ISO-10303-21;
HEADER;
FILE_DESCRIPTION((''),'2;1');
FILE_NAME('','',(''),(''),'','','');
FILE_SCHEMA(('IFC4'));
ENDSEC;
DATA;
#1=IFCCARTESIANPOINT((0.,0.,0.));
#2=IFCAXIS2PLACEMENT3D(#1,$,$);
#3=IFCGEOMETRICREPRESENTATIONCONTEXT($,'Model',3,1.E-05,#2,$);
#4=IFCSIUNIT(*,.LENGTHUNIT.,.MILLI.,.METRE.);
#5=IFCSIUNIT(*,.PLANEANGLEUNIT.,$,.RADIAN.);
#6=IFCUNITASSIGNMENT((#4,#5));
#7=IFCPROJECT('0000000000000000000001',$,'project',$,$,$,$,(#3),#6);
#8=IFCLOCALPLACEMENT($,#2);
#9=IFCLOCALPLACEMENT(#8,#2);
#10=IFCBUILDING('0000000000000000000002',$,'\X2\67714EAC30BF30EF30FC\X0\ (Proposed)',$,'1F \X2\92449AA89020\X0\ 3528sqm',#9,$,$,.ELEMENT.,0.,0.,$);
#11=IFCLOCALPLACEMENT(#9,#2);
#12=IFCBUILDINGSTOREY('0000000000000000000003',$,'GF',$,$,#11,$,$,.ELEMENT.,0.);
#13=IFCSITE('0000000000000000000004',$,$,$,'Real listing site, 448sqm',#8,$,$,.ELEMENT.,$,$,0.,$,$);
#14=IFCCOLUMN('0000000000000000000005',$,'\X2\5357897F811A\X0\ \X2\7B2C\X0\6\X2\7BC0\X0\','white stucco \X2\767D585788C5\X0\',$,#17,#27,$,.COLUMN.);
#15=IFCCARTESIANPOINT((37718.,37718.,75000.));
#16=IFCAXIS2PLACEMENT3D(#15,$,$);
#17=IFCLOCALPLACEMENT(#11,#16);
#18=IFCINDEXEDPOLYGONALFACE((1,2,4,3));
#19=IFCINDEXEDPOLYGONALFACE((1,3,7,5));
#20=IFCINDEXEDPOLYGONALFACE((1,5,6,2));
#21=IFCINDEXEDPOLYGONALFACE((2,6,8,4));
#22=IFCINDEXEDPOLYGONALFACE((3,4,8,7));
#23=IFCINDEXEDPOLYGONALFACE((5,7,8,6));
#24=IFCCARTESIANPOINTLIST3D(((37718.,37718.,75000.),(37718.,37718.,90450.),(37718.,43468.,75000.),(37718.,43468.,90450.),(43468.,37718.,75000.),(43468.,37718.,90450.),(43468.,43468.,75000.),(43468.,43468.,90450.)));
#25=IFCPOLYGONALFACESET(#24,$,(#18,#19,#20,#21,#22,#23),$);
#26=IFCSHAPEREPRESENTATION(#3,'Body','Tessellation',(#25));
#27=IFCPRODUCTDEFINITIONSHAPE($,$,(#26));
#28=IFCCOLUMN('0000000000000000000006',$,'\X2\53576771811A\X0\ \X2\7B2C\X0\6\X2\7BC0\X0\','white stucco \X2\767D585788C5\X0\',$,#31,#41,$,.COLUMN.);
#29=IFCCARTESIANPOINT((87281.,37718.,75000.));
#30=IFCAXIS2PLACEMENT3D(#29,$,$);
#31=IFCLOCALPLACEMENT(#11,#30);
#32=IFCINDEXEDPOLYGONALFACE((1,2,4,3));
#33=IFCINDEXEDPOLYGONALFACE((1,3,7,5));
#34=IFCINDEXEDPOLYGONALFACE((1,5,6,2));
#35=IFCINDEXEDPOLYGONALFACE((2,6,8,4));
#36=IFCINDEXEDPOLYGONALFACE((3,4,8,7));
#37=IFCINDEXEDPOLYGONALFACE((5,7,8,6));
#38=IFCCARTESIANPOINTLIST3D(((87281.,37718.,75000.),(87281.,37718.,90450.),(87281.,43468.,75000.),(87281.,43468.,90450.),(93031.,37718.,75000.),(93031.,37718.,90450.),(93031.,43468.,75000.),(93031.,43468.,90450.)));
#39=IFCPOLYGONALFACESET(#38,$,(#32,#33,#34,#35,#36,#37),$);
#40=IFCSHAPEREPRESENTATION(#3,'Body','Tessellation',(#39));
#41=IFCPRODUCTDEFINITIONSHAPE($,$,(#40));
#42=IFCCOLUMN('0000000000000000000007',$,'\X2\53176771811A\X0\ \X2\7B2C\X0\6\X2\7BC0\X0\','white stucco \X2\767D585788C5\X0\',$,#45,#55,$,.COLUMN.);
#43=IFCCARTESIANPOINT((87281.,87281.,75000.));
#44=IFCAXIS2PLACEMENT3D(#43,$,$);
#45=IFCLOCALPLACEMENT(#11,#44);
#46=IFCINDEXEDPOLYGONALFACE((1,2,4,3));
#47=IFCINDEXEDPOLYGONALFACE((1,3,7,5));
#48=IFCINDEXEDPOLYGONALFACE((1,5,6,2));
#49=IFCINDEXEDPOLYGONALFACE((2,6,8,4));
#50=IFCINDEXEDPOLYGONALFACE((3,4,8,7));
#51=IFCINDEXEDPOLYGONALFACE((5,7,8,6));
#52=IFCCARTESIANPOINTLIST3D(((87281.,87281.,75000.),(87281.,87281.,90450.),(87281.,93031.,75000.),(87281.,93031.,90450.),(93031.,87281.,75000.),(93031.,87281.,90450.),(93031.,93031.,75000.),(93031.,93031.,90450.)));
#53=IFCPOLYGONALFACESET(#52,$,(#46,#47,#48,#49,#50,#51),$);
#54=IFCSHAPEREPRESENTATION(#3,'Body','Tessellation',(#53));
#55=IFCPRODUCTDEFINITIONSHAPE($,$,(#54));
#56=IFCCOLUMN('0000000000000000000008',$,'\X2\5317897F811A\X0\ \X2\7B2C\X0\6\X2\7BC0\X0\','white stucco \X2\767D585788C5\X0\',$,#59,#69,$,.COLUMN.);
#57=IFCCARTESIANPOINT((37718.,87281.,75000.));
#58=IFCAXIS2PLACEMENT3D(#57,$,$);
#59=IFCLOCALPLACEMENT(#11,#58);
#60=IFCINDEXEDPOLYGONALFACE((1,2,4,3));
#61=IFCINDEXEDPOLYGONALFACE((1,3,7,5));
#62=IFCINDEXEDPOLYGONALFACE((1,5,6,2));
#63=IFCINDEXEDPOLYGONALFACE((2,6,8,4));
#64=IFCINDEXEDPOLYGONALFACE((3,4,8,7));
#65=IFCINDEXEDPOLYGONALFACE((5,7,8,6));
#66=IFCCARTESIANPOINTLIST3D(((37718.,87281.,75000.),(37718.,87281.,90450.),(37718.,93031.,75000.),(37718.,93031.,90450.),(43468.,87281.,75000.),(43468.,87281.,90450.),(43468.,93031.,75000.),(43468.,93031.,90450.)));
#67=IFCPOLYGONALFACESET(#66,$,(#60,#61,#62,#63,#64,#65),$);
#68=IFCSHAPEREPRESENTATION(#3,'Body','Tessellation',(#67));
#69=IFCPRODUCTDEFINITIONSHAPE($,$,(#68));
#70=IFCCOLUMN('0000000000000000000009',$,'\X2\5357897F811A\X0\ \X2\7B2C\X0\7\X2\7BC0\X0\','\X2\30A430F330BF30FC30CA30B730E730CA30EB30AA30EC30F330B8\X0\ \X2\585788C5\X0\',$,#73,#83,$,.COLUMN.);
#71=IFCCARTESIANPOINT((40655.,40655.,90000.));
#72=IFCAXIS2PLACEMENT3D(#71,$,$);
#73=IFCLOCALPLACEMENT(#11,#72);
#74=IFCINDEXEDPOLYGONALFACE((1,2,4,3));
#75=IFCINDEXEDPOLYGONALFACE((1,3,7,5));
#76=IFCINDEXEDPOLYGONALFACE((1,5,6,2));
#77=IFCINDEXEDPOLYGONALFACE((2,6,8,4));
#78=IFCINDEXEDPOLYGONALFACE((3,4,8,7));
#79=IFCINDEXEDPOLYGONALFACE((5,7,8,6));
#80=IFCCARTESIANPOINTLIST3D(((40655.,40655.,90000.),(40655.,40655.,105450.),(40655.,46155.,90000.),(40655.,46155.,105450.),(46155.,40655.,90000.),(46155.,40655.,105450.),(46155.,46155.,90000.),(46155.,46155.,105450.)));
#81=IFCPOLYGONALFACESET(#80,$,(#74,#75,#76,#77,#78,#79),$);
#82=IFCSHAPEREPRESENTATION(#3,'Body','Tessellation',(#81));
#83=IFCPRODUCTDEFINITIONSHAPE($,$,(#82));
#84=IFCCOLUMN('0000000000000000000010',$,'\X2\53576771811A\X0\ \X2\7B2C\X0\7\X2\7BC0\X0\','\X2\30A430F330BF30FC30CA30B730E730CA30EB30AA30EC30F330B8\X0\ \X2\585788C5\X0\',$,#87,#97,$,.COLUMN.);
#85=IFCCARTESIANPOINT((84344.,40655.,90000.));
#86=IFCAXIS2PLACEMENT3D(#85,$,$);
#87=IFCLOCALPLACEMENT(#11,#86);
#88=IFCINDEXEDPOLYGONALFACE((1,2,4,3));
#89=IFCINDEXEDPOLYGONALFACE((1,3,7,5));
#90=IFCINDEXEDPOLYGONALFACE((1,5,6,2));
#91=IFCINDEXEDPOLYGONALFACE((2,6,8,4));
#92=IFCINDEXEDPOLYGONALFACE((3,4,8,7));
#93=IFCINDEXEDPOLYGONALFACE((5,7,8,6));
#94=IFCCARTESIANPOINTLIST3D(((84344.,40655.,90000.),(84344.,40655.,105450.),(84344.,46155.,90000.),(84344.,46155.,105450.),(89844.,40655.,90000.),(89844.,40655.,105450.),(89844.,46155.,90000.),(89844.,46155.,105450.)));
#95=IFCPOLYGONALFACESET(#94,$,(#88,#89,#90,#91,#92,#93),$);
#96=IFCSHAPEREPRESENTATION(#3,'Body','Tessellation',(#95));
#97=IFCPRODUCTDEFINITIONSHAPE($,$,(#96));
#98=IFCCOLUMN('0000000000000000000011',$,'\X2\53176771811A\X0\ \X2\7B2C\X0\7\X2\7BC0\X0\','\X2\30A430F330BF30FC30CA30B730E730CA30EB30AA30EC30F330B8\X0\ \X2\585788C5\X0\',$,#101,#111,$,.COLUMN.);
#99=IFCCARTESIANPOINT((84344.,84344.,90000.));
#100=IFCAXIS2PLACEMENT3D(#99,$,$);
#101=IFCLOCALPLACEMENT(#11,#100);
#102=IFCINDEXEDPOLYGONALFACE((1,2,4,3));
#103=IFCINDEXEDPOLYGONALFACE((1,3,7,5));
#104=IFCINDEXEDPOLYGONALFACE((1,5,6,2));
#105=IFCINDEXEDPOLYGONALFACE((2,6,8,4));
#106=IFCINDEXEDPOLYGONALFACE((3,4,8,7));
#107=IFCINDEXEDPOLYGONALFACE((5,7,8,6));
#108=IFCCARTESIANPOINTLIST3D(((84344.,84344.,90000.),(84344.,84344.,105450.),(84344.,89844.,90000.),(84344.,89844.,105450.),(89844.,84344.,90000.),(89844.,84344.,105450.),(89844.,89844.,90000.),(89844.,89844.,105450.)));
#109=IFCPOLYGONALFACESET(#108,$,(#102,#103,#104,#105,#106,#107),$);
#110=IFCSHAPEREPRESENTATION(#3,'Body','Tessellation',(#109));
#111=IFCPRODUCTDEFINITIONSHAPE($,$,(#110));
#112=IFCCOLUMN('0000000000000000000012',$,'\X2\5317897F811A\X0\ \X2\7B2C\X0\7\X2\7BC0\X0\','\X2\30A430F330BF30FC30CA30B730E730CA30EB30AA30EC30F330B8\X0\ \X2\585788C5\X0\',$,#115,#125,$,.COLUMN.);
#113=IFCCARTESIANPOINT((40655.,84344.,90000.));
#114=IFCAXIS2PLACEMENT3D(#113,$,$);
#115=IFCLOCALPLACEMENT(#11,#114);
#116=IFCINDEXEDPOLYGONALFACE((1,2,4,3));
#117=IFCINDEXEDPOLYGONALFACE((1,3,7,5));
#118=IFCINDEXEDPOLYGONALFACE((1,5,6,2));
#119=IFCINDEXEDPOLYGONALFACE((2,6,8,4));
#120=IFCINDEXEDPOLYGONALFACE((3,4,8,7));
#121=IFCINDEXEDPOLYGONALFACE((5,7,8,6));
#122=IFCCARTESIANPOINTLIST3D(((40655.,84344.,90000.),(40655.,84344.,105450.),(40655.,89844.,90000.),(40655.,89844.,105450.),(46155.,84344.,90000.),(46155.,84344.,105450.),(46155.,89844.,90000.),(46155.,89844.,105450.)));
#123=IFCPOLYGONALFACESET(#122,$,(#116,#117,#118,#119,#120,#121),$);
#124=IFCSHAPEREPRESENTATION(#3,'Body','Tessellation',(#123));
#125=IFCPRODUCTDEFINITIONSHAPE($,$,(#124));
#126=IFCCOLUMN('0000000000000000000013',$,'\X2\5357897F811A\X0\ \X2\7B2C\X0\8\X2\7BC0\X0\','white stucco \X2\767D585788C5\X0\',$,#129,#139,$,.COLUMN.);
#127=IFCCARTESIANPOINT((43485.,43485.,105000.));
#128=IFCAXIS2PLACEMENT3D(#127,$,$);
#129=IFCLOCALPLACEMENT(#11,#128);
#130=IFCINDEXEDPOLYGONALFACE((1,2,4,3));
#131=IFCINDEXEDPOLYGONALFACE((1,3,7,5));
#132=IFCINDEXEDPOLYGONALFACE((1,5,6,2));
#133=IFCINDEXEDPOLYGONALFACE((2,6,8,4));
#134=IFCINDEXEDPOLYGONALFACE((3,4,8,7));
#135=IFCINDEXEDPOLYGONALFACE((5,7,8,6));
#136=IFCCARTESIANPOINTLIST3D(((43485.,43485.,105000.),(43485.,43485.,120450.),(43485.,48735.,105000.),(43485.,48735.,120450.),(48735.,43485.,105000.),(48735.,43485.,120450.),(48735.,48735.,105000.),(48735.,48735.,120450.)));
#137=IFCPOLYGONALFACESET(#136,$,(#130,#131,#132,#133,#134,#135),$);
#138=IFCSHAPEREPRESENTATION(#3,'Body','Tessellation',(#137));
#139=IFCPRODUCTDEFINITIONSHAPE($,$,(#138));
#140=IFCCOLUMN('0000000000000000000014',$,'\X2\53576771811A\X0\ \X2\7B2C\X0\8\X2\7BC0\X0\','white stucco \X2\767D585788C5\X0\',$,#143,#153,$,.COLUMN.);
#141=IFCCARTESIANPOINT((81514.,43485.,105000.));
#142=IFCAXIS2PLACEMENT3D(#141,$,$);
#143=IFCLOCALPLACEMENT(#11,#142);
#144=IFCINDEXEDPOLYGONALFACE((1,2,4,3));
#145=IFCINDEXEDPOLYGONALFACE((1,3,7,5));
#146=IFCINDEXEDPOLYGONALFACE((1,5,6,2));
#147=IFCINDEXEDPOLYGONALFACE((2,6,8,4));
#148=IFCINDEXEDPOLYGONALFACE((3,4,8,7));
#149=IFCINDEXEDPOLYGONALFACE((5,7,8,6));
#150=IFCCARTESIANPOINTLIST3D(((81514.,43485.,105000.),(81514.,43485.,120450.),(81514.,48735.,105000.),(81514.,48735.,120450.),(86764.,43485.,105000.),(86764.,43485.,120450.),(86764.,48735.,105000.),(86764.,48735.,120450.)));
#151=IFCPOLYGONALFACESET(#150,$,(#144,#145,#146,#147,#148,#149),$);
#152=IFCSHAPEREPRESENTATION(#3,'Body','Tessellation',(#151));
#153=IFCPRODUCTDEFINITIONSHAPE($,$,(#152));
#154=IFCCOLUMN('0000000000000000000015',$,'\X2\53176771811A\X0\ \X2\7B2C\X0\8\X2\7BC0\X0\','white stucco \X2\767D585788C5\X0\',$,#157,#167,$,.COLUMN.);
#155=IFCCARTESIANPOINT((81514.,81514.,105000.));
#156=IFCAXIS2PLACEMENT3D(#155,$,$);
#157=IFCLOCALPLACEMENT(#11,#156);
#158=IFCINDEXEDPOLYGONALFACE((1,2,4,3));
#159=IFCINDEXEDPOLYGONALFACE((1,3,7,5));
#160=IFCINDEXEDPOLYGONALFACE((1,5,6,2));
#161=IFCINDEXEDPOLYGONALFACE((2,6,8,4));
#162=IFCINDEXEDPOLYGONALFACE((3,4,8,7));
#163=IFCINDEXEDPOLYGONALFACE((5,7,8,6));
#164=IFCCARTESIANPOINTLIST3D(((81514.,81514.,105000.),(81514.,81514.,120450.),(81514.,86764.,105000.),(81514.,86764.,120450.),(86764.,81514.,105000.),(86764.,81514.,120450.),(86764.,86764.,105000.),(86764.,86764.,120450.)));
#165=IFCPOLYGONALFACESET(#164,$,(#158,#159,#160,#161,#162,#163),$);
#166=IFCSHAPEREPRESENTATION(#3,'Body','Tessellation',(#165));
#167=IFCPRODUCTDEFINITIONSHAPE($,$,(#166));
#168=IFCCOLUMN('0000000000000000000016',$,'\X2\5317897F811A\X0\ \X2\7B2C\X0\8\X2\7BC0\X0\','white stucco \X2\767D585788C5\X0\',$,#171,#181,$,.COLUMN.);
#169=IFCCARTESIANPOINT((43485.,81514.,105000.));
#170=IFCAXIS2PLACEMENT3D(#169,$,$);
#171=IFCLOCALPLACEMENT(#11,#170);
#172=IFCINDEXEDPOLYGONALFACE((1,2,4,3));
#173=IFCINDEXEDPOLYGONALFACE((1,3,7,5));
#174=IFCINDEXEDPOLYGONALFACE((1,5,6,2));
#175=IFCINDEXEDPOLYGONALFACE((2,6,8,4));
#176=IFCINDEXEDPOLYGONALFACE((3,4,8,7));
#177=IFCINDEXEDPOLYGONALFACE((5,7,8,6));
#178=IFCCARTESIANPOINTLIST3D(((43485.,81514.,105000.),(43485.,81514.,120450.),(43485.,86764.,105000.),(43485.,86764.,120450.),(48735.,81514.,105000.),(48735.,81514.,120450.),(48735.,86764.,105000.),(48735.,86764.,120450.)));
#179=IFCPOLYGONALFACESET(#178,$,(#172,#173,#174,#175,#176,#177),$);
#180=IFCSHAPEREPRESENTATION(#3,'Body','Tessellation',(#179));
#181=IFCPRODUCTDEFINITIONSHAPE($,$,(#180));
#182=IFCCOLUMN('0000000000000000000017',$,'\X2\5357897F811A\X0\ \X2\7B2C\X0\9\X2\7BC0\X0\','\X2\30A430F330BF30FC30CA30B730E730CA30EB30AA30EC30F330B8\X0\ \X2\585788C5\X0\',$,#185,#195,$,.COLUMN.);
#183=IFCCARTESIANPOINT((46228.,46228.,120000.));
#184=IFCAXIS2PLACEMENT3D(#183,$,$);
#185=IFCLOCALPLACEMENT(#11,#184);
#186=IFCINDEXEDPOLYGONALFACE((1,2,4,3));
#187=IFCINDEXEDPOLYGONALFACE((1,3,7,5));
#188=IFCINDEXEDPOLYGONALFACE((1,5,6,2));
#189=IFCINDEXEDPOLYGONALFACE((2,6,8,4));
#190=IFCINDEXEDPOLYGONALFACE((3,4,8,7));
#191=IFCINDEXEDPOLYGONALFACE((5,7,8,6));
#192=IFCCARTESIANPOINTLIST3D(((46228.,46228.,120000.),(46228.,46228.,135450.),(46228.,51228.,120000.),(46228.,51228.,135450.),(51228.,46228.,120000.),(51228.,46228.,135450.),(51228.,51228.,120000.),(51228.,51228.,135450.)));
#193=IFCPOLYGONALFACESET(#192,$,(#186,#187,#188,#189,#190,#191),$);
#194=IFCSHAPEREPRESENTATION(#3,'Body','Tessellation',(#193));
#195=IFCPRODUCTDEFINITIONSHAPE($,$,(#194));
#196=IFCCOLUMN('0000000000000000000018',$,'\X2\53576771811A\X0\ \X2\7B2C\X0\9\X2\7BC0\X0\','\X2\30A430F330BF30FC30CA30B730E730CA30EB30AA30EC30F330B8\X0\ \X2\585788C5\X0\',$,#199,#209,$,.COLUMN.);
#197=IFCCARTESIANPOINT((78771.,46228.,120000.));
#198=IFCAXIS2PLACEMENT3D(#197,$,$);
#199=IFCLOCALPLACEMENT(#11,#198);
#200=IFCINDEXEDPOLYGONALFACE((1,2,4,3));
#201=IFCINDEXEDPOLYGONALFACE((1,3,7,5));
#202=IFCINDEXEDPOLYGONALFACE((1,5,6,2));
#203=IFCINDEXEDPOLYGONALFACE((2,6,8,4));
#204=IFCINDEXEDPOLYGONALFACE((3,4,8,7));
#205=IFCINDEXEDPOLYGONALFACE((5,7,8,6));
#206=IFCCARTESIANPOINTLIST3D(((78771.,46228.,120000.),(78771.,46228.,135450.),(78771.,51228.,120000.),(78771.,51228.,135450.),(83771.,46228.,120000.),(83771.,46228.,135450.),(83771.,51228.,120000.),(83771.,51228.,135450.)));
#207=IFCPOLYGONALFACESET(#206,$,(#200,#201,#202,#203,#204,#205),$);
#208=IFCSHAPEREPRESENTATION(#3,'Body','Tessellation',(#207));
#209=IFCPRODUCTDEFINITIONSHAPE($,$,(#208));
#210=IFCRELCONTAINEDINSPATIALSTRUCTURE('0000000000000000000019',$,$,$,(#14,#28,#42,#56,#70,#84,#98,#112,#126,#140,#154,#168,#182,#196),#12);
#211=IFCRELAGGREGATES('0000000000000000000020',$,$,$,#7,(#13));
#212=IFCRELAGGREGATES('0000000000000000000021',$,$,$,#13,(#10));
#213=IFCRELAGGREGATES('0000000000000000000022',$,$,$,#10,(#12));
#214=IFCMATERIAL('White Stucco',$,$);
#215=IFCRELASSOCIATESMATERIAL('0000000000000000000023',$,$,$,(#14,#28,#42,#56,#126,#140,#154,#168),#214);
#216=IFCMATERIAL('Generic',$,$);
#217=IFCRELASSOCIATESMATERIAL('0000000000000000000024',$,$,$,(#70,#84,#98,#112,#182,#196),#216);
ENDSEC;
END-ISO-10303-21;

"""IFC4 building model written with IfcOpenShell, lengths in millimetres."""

from ifc_helpers import new_model, si_unit, frame, frame_2d, origin, place, context, project, spatial, rectangle, extrude, material, element, save


model = new_model("IFC4")

# Units and contexts
model_context = context("Model", 3, precision=1e-05, world=origin())
ifc_project = project(units=[si_unit("LENGTHUNIT", "METRE", prefix="MILLI"), si_unit("PLANEANGLEUNIT", "RADIAN")], contexts=[model_context])

# Site, building, storey
site_placement = place(None, origin())
site = spatial("IfcSite", under=ifc_project, at=site_placement, ObjectType="Real listing site, 448sqm", CompositionType="ELEMENT", RefElevation=0.0)
building_placement = place(site_placement, origin())
building = spatial("IfcBuilding", under=site, at=building_placement, Name="東京タワー (Proposed)", ObjectType="1F 鉄骨造 3528sqm", CompositionType="ELEMENT", ElevationOfRefHeight=0.0, ElevationOfTerrain=0.0)
storey_placement = place(building_placement, origin())
storey = spatial("IfcBuildingStorey", under=building, at=storey_placement, Name="GF", CompositionType="ELEMENT", Elevation=0.0)

# Columns
ifc_material_1 = material(Name="White Stucco")
column_1_placement = place(storey_placement, frame((37718.0, 37718.0, 75000.0)))
element("IfcColumn", 1, at=column_1_placement, inside=storey, material=ifc_material_1, Name="南西脚 第6節", Description="white stucco 白塗装", PredefinedType="COLUMN", context=model_context, shape_type="SweptSolid", body=[
    extrude(rectangle(XDim=5750.0, YDim=5750.0, at=frame_2d((2875.0, 2875.0))), frame((37718.0, 37718.0, 75000.0)), (0.0, 0.0, 1.0), 15450.0),
])
column_2_placement = place(storey_placement, frame((87281.0, 37718.0, 75000.0)))
element("IfcColumn", 2, at=column_2_placement, inside=storey, material=ifc_material_1, Name="南東脚 第6節", Description="white stucco 白塗装", PredefinedType="COLUMN", context=model_context, shape_type="SweptSolid", body=[
    extrude(rectangle(XDim=5750.0, YDim=5750.0, at=frame_2d((2875.0, 2875.0))), frame((87281.0, 37718.0, 75000.0)), (0.0, 0.0, 1.0), 15450.0),
])
column_3_placement = place(storey_placement, frame((87281.0, 87281.0, 75000.0)))
element("IfcColumn", 3, at=column_3_placement, inside=storey, material=ifc_material_1, Name="北東脚 第6節", Description="white stucco 白塗装", PredefinedType="COLUMN", context=model_context, shape_type="SweptSolid", body=[
    extrude(rectangle(XDim=5750.0, YDim=5750.0, at=frame_2d((2875.0, 2875.0))), frame((87281.0, 87281.0, 75000.0)), (0.0, 0.0, 1.0), 15450.0),
])
column_4_placement = place(storey_placement, frame((37718.0, 87281.0, 75000.0)))
element("IfcColumn", 4, at=column_4_placement, inside=storey, material=ifc_material_1, Name="北西脚 第6節", Description="white stucco 白塗装", PredefinedType="COLUMN", context=model_context, shape_type="SweptSolid", body=[
    extrude(rectangle(XDim=5750.0, YDim=5750.0, at=frame_2d((2875.0, 2875.0))), frame((37718.0, 87281.0, 75000.0)), (0.0, 0.0, 1.0), 15450.0),
])
ifc_material_2 = material(Name="Generic")
column_5_placement = place(storey_placement, frame((40655.0, 40655.0, 90000.0)))
element("IfcColumn", 5, at=column_5_placement, inside=storey, material=ifc_material_2, Name="南西脚 第7節", Description="インターナショナルオレンジ 塗装", PredefinedType="COLUMN", context=model_context, shape_type="SweptSolid", body=[
    extrude(rectangle(XDim=5500.0, YDim=5500.0, at=frame_2d((2750.0, 2750.0))), frame((40655.0, 40655.0, 90000.0)), (0.0, 0.0, 1.0), 15450.0),
])
column_6_placement = place(storey_placement, frame((84344.0, 40655.0, 90000.0)))
element("IfcColumn", 6, at=column_6_placement, inside=storey, material=ifc_material_2, Name="南東脚 第7節", Description="インターナショナルオレンジ 塗装", PredefinedType="COLUMN", context=model_context, shape_type="SweptSolid", body=[
    extrude(rectangle(XDim=5500.0, YDim=5500.0, at=frame_2d((2750.0, 2750.0))), frame((84344.0, 40655.0, 90000.0)), (0.0, 0.0, 1.0), 15450.0),
])
column_7_placement = place(storey_placement, frame((84344.0, 84344.0, 90000.0)))
element("IfcColumn", 7, at=column_7_placement, inside=storey, material=ifc_material_2, Name="北東脚 第7節", Description="インターナショナルオレンジ 塗装", PredefinedType="COLUMN", context=model_context, shape_type="SweptSolid", body=[
    extrude(rectangle(XDim=5500.0, YDim=5500.0, at=frame_2d((2750.0, 2750.0))), frame((84344.0, 84344.0, 90000.0)), (0.0, 0.0, 1.0), 15450.0),
])
column_8_placement = place(storey_placement, frame((40655.0, 84344.0, 90000.0)))
element("IfcColumn", 8, at=column_8_placement, inside=storey, material=ifc_material_2, Name="北西脚 第7節", Description="インターナショナルオレンジ 塗装", PredefinedType="COLUMN", context=model_context, shape_type="SweptSolid", body=[
    extrude(rectangle(XDim=5500.0, YDim=5500.0, at=frame_2d((2750.0, 2750.0))), frame((40655.0, 84344.0, 90000.0)), (0.0, 0.0, 1.0), 15450.0),
])
column_9_placement = place(storey_placement, frame((43485.0, 43485.0, 105000.0)))
element("IfcColumn", 9, at=column_9_placement, inside=storey, material=ifc_material_1, Name="南西脚 第8節", Description="white stucco 白塗装", PredefinedType="COLUMN", context=model_context, shape_type="SweptSolid", body=[
    extrude(rectangle(XDim=5250.0, YDim=5250.0, at=frame_2d((2625.0, 2625.0))), frame((43485.0, 43485.0, 105000.0)), (0.0, 0.0, 1.0), 15450.0),
])
column_10_placement = place(storey_placement, frame((81514.0, 43485.0, 105000.0)))
element("IfcColumn", 10, at=column_10_placement, inside=storey, material=ifc_material_1, Name="南東脚 第8節", Description="white stucco 白塗装", PredefinedType="COLUMN", context=model_context, shape_type="SweptSolid", body=[
    extrude(rectangle(XDim=5250.0, YDim=5250.0, at=frame_2d((2625.0, 2625.0))), frame((81514.0, 43485.0, 105000.0)), (0.0, 0.0, 1.0), 15450.0),
])
column_11_placement = place(storey_placement, frame((81514.0, 81514.0, 105000.0)))
element("IfcColumn", 11, at=column_11_placement, inside=storey, material=ifc_material_1, Name="北東脚 第8節", Description="white stucco 白塗装", PredefinedType="COLUMN", context=model_context, shape_type="SweptSolid", body=[
    extrude(rectangle(XDim=5250.0, YDim=5250.0, at=frame_2d((2625.0, 2625.0))), frame((81514.0, 81514.0, 105000.0)), (0.0, 0.0, 1.0), 15450.0),
])
column_12_placement = place(storey_placement, frame((43485.0, 81514.0, 105000.0)))
element("IfcColumn", 12, at=column_12_placement, inside=storey, material=ifc_material_1, Name="北西脚 第8節", Description="white stucco 白塗装", PredefinedType="COLUMN", context=model_context, shape_type="SweptSolid", body=[
    extrude(rectangle(XDim=5250.0, YDim=5250.0, at=frame_2d((2625.0, 2625.0))), frame((43485.0, 81514.0, 105000.0)), (0.0, 0.0, 1.0), 15450.0),
])
column_13_placement = place(storey_placement, frame((46228.0, 46228.0, 120000.0)))
element("IfcColumn", 13, at=column_13_placement, inside=storey, material=ifc_material_2, Name="南西脚 第9節", Description="インターナショナルオレンジ 塗装", PredefinedType="COLUMN", context=model_context, shape_type="SweptSolid", body=[
    extrude(rectangle(XDim=5000.0, YDim=5000.0, at=frame_2d((2500.0, 2500.0))), frame((46228.0, 46228.0, 120000.0)), (0.0, 0.0, 1.0), 15450.0),
])
column_14_placement = place(storey_placement, frame((78771.0, 46228.0, 120000.0)))
element("IfcColumn", 14, at=column_14_placement, inside=storey, material=ifc_material_2, Name="南東脚 第9節", Description="インターナショナルオレンジ 塗装", PredefinedType="COLUMN", context=model_context, shape_type="SweptSolid", body=[
    extrude(rectangle(XDim=5000.0, YDim=5000.0, at=frame_2d((2500.0, 2500.0))), frame((78771.0, 46228.0, 120000.0)), (0.0, 0.0, 1.0), 15450.0),
])

save(model, "model.ifc")
